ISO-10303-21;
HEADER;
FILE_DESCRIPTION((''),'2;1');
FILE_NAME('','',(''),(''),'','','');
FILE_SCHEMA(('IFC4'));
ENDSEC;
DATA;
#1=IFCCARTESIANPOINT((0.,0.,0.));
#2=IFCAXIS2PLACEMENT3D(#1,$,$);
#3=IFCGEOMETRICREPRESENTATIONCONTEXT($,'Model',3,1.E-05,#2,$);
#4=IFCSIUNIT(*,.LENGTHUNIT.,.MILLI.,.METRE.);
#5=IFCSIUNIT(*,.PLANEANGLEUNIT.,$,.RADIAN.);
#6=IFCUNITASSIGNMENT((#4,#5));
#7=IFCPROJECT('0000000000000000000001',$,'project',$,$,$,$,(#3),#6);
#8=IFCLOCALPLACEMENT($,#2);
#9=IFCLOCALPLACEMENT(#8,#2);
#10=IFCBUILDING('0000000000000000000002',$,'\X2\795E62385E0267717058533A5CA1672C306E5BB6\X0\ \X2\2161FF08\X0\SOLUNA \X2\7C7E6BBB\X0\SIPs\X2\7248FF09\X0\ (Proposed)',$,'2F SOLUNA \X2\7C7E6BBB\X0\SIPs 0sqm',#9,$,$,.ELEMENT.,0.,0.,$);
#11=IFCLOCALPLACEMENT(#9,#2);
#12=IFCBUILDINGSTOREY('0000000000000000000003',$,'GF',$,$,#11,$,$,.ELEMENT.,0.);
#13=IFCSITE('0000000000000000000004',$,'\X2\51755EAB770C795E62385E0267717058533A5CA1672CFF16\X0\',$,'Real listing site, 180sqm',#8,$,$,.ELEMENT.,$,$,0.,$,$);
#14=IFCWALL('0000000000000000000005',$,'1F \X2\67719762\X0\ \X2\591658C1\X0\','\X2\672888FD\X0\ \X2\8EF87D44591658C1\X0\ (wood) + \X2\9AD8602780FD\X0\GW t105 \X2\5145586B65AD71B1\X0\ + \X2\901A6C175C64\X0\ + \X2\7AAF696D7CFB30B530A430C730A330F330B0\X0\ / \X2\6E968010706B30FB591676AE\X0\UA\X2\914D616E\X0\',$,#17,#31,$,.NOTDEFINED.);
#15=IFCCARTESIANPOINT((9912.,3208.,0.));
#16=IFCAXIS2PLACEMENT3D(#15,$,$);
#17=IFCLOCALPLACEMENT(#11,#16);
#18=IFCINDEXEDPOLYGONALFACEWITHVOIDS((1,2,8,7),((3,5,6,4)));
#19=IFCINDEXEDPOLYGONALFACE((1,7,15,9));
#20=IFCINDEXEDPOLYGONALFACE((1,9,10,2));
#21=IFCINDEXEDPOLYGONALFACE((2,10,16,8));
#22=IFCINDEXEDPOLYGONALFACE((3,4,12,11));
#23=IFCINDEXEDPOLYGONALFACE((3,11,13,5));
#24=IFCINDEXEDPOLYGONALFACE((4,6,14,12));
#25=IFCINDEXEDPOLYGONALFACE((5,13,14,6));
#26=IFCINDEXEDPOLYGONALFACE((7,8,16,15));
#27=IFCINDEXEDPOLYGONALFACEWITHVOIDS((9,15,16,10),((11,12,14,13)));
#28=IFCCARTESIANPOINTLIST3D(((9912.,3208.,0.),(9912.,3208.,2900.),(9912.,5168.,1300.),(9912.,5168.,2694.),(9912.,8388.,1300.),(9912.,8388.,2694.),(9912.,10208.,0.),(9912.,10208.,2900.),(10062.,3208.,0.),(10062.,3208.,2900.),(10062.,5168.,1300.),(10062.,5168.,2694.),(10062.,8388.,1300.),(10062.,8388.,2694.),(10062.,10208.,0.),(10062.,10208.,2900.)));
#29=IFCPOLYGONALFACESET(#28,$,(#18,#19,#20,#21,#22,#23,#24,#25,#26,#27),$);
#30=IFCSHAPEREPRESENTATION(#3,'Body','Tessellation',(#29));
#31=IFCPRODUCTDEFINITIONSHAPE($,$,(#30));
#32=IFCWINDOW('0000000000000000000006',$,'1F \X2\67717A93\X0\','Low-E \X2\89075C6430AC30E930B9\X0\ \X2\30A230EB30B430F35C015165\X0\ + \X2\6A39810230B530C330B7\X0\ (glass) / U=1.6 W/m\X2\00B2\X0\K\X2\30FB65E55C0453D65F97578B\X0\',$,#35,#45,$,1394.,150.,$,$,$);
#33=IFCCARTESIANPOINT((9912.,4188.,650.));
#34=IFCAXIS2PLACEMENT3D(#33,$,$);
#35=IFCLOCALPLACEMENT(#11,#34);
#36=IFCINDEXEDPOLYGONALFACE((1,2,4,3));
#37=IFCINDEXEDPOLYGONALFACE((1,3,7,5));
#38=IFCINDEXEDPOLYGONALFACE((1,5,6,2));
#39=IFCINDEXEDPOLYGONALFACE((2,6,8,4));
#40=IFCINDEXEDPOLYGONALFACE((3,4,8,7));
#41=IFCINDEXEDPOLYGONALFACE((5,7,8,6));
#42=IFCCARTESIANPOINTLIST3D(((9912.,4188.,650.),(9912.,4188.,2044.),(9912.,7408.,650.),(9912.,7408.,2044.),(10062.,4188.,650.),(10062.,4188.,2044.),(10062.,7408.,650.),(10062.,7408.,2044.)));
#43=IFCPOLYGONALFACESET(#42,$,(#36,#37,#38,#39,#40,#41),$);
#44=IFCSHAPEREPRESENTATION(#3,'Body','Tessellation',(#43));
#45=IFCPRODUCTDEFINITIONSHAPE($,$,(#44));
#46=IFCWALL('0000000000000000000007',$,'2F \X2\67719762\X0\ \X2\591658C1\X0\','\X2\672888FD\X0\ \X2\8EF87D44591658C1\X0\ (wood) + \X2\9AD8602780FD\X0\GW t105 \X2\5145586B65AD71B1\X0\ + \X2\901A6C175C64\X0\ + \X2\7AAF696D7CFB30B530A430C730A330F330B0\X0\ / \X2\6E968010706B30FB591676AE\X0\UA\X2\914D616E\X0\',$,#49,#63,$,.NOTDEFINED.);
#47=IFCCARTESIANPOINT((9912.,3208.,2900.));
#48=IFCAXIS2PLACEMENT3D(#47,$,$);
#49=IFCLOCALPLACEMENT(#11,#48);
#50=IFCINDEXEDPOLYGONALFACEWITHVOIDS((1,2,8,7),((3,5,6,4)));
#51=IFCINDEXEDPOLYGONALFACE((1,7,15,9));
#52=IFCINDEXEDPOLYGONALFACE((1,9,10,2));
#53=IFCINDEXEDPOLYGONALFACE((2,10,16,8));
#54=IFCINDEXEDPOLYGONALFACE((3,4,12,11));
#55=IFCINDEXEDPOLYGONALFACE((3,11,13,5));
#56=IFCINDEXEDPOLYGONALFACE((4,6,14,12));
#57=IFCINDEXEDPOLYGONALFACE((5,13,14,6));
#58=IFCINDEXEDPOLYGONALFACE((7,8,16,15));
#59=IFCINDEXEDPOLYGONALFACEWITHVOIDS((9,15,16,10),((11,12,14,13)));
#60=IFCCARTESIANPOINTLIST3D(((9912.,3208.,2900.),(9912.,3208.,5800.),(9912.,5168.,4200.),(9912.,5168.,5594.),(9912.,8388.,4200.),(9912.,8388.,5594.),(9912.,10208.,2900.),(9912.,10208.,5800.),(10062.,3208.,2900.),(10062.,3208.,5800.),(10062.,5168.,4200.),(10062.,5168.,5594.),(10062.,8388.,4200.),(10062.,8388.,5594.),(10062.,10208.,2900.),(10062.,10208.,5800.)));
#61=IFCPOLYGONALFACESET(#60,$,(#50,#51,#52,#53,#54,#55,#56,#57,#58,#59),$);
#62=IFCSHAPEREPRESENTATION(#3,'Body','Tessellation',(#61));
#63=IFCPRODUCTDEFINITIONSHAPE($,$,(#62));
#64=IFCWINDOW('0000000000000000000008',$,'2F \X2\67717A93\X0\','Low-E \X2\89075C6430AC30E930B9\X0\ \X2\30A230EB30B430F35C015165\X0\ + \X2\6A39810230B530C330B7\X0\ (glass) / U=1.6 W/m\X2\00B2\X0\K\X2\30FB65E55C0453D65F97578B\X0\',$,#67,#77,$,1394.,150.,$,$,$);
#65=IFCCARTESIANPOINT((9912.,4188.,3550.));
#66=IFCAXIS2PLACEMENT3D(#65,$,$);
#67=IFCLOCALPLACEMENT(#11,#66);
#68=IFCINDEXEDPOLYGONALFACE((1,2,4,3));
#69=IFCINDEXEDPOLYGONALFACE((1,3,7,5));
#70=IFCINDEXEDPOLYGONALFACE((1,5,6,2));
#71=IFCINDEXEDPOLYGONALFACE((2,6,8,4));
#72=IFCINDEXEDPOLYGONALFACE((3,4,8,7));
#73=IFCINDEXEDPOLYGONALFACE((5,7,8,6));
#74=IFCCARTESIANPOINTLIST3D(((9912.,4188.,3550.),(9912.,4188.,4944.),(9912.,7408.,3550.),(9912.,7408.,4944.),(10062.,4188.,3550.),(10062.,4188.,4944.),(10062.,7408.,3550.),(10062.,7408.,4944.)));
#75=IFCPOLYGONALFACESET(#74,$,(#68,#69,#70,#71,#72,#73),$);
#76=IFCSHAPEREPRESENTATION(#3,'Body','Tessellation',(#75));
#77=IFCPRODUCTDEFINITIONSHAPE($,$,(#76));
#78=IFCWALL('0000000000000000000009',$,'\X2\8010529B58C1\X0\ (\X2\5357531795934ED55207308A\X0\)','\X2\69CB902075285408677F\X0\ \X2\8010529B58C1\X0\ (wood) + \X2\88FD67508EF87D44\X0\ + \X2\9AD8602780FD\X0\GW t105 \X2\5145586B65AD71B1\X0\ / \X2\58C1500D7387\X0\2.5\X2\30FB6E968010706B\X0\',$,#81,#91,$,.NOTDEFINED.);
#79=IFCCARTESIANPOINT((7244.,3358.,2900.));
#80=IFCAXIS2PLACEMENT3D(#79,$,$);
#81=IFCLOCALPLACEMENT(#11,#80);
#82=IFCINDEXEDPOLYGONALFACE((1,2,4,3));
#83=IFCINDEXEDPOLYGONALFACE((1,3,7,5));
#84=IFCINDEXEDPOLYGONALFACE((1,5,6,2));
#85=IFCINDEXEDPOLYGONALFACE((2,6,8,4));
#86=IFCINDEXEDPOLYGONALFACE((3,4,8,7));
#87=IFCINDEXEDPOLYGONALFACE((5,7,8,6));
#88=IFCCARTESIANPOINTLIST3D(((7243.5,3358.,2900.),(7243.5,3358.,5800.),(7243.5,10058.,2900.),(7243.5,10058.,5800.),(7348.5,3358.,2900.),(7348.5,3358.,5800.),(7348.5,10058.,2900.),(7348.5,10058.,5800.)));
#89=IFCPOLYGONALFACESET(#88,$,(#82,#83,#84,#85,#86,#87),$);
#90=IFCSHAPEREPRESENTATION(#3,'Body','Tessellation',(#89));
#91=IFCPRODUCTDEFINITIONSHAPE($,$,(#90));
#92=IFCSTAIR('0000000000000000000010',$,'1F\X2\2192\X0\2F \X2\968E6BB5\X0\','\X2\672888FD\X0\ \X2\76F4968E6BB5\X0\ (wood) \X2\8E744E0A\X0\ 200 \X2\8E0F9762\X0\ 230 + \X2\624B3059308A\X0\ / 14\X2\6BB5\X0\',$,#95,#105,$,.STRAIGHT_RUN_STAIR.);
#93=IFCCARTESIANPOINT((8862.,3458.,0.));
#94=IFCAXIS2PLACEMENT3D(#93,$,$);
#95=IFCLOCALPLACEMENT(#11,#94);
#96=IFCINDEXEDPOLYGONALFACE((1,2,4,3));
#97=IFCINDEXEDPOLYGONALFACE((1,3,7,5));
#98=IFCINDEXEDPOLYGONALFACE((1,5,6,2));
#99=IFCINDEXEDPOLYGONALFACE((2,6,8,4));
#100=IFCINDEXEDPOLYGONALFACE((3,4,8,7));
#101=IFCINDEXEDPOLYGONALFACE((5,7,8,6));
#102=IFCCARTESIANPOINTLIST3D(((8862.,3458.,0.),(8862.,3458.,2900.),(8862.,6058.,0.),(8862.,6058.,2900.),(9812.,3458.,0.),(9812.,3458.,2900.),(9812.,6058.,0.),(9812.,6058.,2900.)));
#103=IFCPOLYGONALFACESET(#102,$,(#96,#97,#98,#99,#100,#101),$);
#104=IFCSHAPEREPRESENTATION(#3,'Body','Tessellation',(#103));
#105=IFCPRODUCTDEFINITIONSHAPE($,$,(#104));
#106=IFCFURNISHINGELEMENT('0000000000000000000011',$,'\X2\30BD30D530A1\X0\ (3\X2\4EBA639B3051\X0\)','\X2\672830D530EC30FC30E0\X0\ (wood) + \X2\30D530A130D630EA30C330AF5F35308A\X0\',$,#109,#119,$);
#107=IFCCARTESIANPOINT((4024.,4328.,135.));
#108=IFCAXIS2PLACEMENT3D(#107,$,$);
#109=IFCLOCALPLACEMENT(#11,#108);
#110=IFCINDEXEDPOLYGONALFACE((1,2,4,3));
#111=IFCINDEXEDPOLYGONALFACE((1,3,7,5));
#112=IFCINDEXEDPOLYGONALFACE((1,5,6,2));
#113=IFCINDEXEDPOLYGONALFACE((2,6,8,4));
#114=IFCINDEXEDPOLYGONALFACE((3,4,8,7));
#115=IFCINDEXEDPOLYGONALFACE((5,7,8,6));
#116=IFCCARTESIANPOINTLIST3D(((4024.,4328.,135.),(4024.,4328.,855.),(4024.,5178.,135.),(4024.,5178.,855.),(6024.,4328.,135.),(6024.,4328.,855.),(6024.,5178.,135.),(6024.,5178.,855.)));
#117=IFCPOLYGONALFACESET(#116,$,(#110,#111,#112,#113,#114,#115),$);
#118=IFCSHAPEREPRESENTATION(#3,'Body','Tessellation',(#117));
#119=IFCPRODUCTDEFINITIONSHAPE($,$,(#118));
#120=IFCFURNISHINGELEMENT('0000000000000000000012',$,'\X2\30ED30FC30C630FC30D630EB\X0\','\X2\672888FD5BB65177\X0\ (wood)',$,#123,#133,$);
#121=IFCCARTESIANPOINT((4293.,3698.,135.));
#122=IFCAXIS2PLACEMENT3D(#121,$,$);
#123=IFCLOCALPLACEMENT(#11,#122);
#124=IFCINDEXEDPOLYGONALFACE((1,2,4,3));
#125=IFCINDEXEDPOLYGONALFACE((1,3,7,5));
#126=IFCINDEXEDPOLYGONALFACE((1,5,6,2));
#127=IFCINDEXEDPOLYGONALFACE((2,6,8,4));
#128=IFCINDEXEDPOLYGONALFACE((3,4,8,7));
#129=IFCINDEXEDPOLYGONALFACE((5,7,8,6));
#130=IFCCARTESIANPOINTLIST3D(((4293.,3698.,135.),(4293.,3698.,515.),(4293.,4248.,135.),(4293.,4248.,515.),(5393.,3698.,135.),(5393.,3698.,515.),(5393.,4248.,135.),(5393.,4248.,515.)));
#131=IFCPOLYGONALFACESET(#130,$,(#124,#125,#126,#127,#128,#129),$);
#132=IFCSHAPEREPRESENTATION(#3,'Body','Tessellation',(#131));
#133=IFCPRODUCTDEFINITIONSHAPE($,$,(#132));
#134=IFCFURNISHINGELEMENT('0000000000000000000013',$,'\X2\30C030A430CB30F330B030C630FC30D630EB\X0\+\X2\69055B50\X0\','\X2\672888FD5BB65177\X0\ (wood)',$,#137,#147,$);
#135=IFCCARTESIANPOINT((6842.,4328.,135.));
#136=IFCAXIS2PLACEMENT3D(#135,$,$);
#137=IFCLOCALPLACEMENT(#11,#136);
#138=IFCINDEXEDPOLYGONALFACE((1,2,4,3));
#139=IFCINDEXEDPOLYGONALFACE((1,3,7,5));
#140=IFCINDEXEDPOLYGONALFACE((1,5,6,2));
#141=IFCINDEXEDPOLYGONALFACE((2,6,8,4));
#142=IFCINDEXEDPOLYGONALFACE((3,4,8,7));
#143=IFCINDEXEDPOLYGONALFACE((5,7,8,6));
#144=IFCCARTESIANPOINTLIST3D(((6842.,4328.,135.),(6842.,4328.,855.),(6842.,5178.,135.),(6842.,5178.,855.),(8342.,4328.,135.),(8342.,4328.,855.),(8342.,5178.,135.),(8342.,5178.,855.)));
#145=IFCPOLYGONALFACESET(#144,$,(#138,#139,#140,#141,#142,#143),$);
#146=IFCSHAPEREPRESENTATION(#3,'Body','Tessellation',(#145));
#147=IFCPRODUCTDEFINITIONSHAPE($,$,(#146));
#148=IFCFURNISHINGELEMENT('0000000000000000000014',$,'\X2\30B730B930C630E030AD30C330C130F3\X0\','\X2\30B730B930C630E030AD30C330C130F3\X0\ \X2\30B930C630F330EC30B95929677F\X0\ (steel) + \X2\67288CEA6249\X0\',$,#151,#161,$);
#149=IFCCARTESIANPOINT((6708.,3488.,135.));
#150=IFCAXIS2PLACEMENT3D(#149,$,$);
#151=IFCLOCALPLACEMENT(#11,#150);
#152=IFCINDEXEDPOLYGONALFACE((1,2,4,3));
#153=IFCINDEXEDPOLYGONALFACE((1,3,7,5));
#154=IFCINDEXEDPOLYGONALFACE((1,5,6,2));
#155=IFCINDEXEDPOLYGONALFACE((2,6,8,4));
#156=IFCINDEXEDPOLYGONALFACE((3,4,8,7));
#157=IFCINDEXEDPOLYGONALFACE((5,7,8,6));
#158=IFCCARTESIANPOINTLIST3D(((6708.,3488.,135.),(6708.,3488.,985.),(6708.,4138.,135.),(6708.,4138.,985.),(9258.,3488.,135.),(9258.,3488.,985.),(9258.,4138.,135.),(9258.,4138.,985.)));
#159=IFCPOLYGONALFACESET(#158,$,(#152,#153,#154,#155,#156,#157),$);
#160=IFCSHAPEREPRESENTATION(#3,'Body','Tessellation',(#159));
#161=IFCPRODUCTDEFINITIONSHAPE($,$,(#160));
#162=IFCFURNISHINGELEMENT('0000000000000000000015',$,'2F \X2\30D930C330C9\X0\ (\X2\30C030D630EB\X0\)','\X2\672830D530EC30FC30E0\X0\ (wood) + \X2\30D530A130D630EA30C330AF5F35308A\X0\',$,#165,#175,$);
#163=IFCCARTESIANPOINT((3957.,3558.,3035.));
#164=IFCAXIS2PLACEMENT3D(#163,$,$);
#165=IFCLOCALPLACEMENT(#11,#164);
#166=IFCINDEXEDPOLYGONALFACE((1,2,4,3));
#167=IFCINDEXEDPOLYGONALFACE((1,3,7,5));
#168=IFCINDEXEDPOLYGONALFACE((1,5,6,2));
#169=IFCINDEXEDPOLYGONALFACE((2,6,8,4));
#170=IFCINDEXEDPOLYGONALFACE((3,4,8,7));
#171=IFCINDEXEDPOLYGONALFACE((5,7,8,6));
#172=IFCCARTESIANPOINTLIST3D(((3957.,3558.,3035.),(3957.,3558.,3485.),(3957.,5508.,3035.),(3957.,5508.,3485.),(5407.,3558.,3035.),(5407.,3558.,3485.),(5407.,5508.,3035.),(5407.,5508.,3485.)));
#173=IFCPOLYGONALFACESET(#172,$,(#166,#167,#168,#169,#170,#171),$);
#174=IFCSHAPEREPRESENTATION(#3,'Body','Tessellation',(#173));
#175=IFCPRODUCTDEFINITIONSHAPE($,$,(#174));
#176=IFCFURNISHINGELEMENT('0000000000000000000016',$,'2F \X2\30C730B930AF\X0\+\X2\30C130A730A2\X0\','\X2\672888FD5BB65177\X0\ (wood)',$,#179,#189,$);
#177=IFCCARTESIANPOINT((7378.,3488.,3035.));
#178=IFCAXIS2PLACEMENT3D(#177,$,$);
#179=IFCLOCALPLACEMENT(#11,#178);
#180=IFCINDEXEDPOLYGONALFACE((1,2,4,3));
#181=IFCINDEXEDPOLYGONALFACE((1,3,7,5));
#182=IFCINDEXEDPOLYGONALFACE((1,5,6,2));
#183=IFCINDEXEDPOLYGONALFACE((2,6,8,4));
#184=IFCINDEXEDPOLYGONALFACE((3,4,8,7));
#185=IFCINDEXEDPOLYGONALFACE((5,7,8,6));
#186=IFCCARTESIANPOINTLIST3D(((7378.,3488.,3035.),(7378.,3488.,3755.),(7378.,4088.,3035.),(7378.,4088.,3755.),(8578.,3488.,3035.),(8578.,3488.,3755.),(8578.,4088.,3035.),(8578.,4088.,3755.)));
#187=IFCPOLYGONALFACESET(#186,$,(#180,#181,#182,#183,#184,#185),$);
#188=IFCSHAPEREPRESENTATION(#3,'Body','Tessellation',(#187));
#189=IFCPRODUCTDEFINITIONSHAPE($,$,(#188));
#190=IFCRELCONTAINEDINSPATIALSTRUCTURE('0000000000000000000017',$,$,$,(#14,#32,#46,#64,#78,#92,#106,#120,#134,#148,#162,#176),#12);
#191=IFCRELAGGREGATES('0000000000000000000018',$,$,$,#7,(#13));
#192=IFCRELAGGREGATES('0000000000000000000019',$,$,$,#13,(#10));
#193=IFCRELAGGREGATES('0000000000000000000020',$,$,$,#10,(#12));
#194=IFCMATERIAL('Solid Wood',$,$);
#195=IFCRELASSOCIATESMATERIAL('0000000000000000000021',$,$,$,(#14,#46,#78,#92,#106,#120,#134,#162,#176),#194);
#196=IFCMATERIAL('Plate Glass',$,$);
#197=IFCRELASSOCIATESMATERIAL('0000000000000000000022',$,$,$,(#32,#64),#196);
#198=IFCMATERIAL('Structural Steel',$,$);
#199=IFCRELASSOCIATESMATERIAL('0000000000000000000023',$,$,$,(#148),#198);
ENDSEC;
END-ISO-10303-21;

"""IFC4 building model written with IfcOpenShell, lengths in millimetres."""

from ifc_helpers import new_model, si_unit, frame, frame_2d, origin, place, context, project, spatial, rectangle, extrude, material, element, fill, save


model = new_model("IFC4")

# Units and contexts
model_context = context("Model", 3, precision=1e-05, world=origin())
ifc_project = project(units=[si_unit("LENGTHUNIT", "METRE", prefix="MILLI"), si_unit("PLANEANGLEUNIT", "RADIAN")], contexts=[model_context])

# Site, building, storey
site_placement = place(None, origin())
site = spatial("IfcSite", under=ifc_project, at=site_placement, Name="兵庫県神戸市東灘区岡本６", ObjectType="Real listing site, 180sqm", CompositionType="ELEMENT", RefElevation=0.0)
building_placement = place(site_placement, origin())
building = spatial("IfcBuilding", under=site, at=building_placement, Name="神戸市東灘区岡本の家 Ⅱ（SOLUNA 籾殻SIPs版） (Proposed)", ObjectType="2F SOLUNA 籾殻SIPs 0sqm", CompositionType="ELEMENT", ElevationOfRefHeight=0.0, ElevationOfTerrain=0.0)
storey_placement = place(building_placement, origin())
storey = spatial("IfcBuildingStorey", under=building, at=storey_placement, Name="GF", CompositionType="ELEMENT", Elevation=0.0)

# Wall, opening, window
ifc_material_1 = material(Name="Solid Wood")
wall_1_placement = place(storey_placement, frame((9912.0, 3208.0, 0.0)))
wall_1 = element("IfcWall", 1, at=wall_1_placement, inside=storey, material=ifc_material_1, Name="1F 東面 外壁", Description="木製 軸組外壁 (wood) + 高性能GW t105 充填断熱 + 通気層 + 窯業系サイディング / 準耐火・外皮UA配慮", PredefinedType="NOTDEFINED", context=model_context, shape_type="SweptSolid", body=[
    extrude(rectangle(XDim=150.0, YDim=7000.0, at=frame_2d((75.0, 3500.0))), frame((9912.0, 3208.0, 0.0)), (0.0, 0.0, 1.0), 2900.0),
])
opening_1_placement = place(storey_placement, frame((9912.0, 4188.0, 650.0)))
opening_1 = element("IfcOpeningElement", 2, at=opening_1_placement, cuts=wall_1, PredefinedType="NOTDEFINED", context=model_context, shape_type="SweptSolid", body=[
    extrude(rectangle(XDim=150.0, YDim=3220.0, at=frame_2d((75.0, 1610.0))), frame((9912.0, 4188.0, 650.0)), (0.0, 0.0, 1.0), 1394.0),
])
ifc_material_2 = material(Name="Plate Glass")
window_1_placement = place(storey_placement, frame((9912.0, 4188.0, 650.0)))
window_1 = element("IfcWindow", 3, at=window_1_placement, inside=storey, material=ifc_material_2, Name="1F 東窓", Description="Low-E 複層ガラス アルゴン封入 + 樹脂サッシ (glass) / U=1.6 W/m²K・日射取得型", OverallHeight=1394.0, OverallWidth=150.0, context=model_context, shape_type="SweptSolid", body=[
    extrude(rectangle(XDim=150.0, YDim=3220.0, at=frame_2d((75.0, 1610.0))), frame((9912.0, 4188.0, 650.0)), (0.0, 0.0, 1.0), 1394.0),
])
fill(opening_1, window_1)

# Wall, opening, window
wall_2_placement = place(storey_placement, frame((9912.0, 3208.0, 2900.0)))
wall_2 = element("IfcWall", 4, at=wall_2_placement, inside=storey, material=ifc_material_1, Name="2F 東面 外壁", Description="木製 軸組外壁 (wood) + 高性能GW t105 充填断熱 + 通気層 + 窯業系サイディング / 準耐火・外皮UA配慮", PredefinedType="NOTDEFINED", context=model_context, shape_type="SweptSolid", body=[
    extrude(rectangle(XDim=150.0, YDim=7000.0, at=frame_2d((75.0, 3500.0))), frame((9912.0, 3208.0, 2900.0)), (0.0, 0.0, 1.0), 2900.0),
])
opening_2_placement = place(storey_placement, frame((9912.0, 4188.0, 3550.0)))
opening_2 = element("IfcOpeningElement", 5, at=opening_2_placement, cuts=wall_2, PredefinedType="NOTDEFINED", context=model_context, shape_type="SweptSolid", body=[
    extrude(rectangle(XDim=150.0, YDim=3220.0, at=frame_2d((75.0, 1610.0))), frame((9912.0, 4188.0, 3550.0)), (0.0, 0.0, 1.0), 1394.0),
])
window_2_placement = place(storey_placement, frame((9912.0, 4188.0, 3550.0)))
window_2 = element("IfcWindow", 6, at=window_2_placement, inside=storey, material=ifc_material_2, Name="2F 東窓", Description="Low-E 複層ガラス アルゴン封入 + 樹脂サッシ (glass) / U=1.6 W/m²K・日射取得型", OverallHeight=1394.0, OverallWidth=150.0, context=model_context, shape_type="SweptSolid", body=[
    extrude(rectangle(XDim=150.0, YDim=3220.0, at=frame_2d((75.0, 1610.0))), frame((9912.0, 4188.0, 3550.0)), (0.0, 0.0, 1.0), 1394.0),
])
fill(opening_2, window_2)

# Wall
wall_3_placement = place(storey_placement, frame((7244.0, 3358.0, 2900.0)))
element("IfcWall", 7, at=wall_3_placement, inside=storey, material=ifc_material_1, Name="耐力壁 (南北間仕切り)", Description="構造用合板 耐力壁 (wood) + 製材軸組 + 高性能GW t105 充填断熱 / 壁倍率2.5・準耐火", PredefinedType="NOTDEFINED", context=model_context, shape_type="SweptSolid", body=[
    extrude(rectangle(XDim=105.0, YDim=6700.0, at=frame_2d((52.0, 3350.0))), frame((7244.0, 3358.0, 2900.0)), (0.0, 0.0, 1.0), 2900.0),
])

# Stair
stair_placement = place(storey_placement, frame((8862.0, 3458.0, 0.0)))
element("IfcStair", 8, at=stair_placement, inside=storey, material=ifc_material_1, Name="1F→2F 階段", Description="木製 直階段 (wood) 蹴上 200 踏面 230 + 手すり / 14段", PredefinedType="STRAIGHT_RUN_STAIR", context=model_context, shape_type="SweptSolid", body=[
    extrude(rectangle(XDim=950.0, YDim=2600.0, at=frame_2d((475.0, 1300.0))), frame((8862.0, 3458.0, 0.0)), (0.0, 0.0, 1.0), 2900.0),
])

# Furnishing elements
furnishing_1_placement = place(storey_placement, frame((4024.0, 4328.0, 135.0)))
element("IfcFurnishingElement", 9, at=furnishing_1_placement, inside=storey, material=ifc_material_1, Name="ソファ (3人掛け)", Description="木フレーム (wood) + ファブリック張り", context=model_context, shape_type="SweptSolid", body=[
    extrude(rectangle(XDim=2000.0, YDim=850.0, at=frame_2d((1000.0, 425.0))), frame((4024.0, 4328.0, 135.0)), (0.0, 0.0, 1.0), 720.0),
])
furnishing_2_placement = place(storey_placement, frame((4293.0, 3698.0, 135.0)))
element("IfcFurnishingElement", 10, at=furnishing_2_placement, inside=storey, material=ifc_material_1, Name="ローテーブル", Description="木製家具 (wood)", context=model_context, shape_type="SweptSolid", body=[
    extrude(rectangle(XDim=1100.0, YDim=550.0, at=frame_2d((550.0, 275.0))), frame((4293.0, 3698.0, 135.0)), (0.0, 0.0, 1.0), 380.0),
])
furnishing_3_placement = place(storey_placement, frame((6842.0, 4328.0, 135.0)))
element("IfcFurnishingElement", 11, at=furnishing_3_placement, inside=storey, material=ifc_material_1, Name="ダイニングテーブル+椅子", Description="木製家具 (wood)", context=model_context, shape_type="SweptSolid", body=[
    extrude(rectangle(XDim=1500.0, YDim=850.0, at=frame_2d((750.0, 425.0))), frame((6842.0, 4328.0, 135.0)), (0.0, 0.0, 1.0), 720.0),
])
ifc_material_3 = material(Name="Structural Steel")
furnishing_4_placement = place(storey_placement, frame((6708.0, 3488.0, 135.0)))
element("IfcFurnishingElement", 12, at=furnishing_4_placement, inside=storey, material=ifc_material_3, Name="システムキッチン", Description="システムキッチン ステンレス天板 (steel) + 木質扉", context=model_context, shape_type="SweptSolid", body=[
    extrude(rectangle(XDim=2550.0, YDim=650.0, at=frame_2d((1275.0, 325.0))), frame((6708.0, 3488.0, 135.0)), (0.0, 0.0, 1.0), 850.0),
])
furnishing_5_placement = place(storey_placement, frame((3957.0, 3558.0, 3035.0)))
element("IfcFurnishingElement", 13, at=furnishing_5_placement, inside=storey, material=ifc_material_1, Name="2F ベッド (ダブル)", Description="木フレーム (wood) + ファブリック張り", context=model_context, shape_type="SweptSolid", body=[
    extrude(rectangle(XDim=1450.0, YDim=1950.0, at=frame_2d((725.0, 975.0))), frame((3957.0, 3558.0, 3035.0)), (0.0, 0.0, 1.0), 450.0),
])
furnishing_6_placement = place(storey_placement, frame((7378.0, 3488.0, 3035.0)))
element("IfcFurnishingElement", 14, at=furnishing_6_placement, inside=storey, material=ifc_material_1, Name="2F デスク+チェア", Description="木製家具 (wood)", context=model_context, shape_type="SweptSolid", body=[
    extrude(rectangle(XDim=1200.0, YDim=600.0, at=frame_2d((600.0, 300.0))), frame((7378.0, 3488.0, 3035.0)), (0.0, 0.0, 1.0), 720.0),
])

save(model, "model.ifc")
